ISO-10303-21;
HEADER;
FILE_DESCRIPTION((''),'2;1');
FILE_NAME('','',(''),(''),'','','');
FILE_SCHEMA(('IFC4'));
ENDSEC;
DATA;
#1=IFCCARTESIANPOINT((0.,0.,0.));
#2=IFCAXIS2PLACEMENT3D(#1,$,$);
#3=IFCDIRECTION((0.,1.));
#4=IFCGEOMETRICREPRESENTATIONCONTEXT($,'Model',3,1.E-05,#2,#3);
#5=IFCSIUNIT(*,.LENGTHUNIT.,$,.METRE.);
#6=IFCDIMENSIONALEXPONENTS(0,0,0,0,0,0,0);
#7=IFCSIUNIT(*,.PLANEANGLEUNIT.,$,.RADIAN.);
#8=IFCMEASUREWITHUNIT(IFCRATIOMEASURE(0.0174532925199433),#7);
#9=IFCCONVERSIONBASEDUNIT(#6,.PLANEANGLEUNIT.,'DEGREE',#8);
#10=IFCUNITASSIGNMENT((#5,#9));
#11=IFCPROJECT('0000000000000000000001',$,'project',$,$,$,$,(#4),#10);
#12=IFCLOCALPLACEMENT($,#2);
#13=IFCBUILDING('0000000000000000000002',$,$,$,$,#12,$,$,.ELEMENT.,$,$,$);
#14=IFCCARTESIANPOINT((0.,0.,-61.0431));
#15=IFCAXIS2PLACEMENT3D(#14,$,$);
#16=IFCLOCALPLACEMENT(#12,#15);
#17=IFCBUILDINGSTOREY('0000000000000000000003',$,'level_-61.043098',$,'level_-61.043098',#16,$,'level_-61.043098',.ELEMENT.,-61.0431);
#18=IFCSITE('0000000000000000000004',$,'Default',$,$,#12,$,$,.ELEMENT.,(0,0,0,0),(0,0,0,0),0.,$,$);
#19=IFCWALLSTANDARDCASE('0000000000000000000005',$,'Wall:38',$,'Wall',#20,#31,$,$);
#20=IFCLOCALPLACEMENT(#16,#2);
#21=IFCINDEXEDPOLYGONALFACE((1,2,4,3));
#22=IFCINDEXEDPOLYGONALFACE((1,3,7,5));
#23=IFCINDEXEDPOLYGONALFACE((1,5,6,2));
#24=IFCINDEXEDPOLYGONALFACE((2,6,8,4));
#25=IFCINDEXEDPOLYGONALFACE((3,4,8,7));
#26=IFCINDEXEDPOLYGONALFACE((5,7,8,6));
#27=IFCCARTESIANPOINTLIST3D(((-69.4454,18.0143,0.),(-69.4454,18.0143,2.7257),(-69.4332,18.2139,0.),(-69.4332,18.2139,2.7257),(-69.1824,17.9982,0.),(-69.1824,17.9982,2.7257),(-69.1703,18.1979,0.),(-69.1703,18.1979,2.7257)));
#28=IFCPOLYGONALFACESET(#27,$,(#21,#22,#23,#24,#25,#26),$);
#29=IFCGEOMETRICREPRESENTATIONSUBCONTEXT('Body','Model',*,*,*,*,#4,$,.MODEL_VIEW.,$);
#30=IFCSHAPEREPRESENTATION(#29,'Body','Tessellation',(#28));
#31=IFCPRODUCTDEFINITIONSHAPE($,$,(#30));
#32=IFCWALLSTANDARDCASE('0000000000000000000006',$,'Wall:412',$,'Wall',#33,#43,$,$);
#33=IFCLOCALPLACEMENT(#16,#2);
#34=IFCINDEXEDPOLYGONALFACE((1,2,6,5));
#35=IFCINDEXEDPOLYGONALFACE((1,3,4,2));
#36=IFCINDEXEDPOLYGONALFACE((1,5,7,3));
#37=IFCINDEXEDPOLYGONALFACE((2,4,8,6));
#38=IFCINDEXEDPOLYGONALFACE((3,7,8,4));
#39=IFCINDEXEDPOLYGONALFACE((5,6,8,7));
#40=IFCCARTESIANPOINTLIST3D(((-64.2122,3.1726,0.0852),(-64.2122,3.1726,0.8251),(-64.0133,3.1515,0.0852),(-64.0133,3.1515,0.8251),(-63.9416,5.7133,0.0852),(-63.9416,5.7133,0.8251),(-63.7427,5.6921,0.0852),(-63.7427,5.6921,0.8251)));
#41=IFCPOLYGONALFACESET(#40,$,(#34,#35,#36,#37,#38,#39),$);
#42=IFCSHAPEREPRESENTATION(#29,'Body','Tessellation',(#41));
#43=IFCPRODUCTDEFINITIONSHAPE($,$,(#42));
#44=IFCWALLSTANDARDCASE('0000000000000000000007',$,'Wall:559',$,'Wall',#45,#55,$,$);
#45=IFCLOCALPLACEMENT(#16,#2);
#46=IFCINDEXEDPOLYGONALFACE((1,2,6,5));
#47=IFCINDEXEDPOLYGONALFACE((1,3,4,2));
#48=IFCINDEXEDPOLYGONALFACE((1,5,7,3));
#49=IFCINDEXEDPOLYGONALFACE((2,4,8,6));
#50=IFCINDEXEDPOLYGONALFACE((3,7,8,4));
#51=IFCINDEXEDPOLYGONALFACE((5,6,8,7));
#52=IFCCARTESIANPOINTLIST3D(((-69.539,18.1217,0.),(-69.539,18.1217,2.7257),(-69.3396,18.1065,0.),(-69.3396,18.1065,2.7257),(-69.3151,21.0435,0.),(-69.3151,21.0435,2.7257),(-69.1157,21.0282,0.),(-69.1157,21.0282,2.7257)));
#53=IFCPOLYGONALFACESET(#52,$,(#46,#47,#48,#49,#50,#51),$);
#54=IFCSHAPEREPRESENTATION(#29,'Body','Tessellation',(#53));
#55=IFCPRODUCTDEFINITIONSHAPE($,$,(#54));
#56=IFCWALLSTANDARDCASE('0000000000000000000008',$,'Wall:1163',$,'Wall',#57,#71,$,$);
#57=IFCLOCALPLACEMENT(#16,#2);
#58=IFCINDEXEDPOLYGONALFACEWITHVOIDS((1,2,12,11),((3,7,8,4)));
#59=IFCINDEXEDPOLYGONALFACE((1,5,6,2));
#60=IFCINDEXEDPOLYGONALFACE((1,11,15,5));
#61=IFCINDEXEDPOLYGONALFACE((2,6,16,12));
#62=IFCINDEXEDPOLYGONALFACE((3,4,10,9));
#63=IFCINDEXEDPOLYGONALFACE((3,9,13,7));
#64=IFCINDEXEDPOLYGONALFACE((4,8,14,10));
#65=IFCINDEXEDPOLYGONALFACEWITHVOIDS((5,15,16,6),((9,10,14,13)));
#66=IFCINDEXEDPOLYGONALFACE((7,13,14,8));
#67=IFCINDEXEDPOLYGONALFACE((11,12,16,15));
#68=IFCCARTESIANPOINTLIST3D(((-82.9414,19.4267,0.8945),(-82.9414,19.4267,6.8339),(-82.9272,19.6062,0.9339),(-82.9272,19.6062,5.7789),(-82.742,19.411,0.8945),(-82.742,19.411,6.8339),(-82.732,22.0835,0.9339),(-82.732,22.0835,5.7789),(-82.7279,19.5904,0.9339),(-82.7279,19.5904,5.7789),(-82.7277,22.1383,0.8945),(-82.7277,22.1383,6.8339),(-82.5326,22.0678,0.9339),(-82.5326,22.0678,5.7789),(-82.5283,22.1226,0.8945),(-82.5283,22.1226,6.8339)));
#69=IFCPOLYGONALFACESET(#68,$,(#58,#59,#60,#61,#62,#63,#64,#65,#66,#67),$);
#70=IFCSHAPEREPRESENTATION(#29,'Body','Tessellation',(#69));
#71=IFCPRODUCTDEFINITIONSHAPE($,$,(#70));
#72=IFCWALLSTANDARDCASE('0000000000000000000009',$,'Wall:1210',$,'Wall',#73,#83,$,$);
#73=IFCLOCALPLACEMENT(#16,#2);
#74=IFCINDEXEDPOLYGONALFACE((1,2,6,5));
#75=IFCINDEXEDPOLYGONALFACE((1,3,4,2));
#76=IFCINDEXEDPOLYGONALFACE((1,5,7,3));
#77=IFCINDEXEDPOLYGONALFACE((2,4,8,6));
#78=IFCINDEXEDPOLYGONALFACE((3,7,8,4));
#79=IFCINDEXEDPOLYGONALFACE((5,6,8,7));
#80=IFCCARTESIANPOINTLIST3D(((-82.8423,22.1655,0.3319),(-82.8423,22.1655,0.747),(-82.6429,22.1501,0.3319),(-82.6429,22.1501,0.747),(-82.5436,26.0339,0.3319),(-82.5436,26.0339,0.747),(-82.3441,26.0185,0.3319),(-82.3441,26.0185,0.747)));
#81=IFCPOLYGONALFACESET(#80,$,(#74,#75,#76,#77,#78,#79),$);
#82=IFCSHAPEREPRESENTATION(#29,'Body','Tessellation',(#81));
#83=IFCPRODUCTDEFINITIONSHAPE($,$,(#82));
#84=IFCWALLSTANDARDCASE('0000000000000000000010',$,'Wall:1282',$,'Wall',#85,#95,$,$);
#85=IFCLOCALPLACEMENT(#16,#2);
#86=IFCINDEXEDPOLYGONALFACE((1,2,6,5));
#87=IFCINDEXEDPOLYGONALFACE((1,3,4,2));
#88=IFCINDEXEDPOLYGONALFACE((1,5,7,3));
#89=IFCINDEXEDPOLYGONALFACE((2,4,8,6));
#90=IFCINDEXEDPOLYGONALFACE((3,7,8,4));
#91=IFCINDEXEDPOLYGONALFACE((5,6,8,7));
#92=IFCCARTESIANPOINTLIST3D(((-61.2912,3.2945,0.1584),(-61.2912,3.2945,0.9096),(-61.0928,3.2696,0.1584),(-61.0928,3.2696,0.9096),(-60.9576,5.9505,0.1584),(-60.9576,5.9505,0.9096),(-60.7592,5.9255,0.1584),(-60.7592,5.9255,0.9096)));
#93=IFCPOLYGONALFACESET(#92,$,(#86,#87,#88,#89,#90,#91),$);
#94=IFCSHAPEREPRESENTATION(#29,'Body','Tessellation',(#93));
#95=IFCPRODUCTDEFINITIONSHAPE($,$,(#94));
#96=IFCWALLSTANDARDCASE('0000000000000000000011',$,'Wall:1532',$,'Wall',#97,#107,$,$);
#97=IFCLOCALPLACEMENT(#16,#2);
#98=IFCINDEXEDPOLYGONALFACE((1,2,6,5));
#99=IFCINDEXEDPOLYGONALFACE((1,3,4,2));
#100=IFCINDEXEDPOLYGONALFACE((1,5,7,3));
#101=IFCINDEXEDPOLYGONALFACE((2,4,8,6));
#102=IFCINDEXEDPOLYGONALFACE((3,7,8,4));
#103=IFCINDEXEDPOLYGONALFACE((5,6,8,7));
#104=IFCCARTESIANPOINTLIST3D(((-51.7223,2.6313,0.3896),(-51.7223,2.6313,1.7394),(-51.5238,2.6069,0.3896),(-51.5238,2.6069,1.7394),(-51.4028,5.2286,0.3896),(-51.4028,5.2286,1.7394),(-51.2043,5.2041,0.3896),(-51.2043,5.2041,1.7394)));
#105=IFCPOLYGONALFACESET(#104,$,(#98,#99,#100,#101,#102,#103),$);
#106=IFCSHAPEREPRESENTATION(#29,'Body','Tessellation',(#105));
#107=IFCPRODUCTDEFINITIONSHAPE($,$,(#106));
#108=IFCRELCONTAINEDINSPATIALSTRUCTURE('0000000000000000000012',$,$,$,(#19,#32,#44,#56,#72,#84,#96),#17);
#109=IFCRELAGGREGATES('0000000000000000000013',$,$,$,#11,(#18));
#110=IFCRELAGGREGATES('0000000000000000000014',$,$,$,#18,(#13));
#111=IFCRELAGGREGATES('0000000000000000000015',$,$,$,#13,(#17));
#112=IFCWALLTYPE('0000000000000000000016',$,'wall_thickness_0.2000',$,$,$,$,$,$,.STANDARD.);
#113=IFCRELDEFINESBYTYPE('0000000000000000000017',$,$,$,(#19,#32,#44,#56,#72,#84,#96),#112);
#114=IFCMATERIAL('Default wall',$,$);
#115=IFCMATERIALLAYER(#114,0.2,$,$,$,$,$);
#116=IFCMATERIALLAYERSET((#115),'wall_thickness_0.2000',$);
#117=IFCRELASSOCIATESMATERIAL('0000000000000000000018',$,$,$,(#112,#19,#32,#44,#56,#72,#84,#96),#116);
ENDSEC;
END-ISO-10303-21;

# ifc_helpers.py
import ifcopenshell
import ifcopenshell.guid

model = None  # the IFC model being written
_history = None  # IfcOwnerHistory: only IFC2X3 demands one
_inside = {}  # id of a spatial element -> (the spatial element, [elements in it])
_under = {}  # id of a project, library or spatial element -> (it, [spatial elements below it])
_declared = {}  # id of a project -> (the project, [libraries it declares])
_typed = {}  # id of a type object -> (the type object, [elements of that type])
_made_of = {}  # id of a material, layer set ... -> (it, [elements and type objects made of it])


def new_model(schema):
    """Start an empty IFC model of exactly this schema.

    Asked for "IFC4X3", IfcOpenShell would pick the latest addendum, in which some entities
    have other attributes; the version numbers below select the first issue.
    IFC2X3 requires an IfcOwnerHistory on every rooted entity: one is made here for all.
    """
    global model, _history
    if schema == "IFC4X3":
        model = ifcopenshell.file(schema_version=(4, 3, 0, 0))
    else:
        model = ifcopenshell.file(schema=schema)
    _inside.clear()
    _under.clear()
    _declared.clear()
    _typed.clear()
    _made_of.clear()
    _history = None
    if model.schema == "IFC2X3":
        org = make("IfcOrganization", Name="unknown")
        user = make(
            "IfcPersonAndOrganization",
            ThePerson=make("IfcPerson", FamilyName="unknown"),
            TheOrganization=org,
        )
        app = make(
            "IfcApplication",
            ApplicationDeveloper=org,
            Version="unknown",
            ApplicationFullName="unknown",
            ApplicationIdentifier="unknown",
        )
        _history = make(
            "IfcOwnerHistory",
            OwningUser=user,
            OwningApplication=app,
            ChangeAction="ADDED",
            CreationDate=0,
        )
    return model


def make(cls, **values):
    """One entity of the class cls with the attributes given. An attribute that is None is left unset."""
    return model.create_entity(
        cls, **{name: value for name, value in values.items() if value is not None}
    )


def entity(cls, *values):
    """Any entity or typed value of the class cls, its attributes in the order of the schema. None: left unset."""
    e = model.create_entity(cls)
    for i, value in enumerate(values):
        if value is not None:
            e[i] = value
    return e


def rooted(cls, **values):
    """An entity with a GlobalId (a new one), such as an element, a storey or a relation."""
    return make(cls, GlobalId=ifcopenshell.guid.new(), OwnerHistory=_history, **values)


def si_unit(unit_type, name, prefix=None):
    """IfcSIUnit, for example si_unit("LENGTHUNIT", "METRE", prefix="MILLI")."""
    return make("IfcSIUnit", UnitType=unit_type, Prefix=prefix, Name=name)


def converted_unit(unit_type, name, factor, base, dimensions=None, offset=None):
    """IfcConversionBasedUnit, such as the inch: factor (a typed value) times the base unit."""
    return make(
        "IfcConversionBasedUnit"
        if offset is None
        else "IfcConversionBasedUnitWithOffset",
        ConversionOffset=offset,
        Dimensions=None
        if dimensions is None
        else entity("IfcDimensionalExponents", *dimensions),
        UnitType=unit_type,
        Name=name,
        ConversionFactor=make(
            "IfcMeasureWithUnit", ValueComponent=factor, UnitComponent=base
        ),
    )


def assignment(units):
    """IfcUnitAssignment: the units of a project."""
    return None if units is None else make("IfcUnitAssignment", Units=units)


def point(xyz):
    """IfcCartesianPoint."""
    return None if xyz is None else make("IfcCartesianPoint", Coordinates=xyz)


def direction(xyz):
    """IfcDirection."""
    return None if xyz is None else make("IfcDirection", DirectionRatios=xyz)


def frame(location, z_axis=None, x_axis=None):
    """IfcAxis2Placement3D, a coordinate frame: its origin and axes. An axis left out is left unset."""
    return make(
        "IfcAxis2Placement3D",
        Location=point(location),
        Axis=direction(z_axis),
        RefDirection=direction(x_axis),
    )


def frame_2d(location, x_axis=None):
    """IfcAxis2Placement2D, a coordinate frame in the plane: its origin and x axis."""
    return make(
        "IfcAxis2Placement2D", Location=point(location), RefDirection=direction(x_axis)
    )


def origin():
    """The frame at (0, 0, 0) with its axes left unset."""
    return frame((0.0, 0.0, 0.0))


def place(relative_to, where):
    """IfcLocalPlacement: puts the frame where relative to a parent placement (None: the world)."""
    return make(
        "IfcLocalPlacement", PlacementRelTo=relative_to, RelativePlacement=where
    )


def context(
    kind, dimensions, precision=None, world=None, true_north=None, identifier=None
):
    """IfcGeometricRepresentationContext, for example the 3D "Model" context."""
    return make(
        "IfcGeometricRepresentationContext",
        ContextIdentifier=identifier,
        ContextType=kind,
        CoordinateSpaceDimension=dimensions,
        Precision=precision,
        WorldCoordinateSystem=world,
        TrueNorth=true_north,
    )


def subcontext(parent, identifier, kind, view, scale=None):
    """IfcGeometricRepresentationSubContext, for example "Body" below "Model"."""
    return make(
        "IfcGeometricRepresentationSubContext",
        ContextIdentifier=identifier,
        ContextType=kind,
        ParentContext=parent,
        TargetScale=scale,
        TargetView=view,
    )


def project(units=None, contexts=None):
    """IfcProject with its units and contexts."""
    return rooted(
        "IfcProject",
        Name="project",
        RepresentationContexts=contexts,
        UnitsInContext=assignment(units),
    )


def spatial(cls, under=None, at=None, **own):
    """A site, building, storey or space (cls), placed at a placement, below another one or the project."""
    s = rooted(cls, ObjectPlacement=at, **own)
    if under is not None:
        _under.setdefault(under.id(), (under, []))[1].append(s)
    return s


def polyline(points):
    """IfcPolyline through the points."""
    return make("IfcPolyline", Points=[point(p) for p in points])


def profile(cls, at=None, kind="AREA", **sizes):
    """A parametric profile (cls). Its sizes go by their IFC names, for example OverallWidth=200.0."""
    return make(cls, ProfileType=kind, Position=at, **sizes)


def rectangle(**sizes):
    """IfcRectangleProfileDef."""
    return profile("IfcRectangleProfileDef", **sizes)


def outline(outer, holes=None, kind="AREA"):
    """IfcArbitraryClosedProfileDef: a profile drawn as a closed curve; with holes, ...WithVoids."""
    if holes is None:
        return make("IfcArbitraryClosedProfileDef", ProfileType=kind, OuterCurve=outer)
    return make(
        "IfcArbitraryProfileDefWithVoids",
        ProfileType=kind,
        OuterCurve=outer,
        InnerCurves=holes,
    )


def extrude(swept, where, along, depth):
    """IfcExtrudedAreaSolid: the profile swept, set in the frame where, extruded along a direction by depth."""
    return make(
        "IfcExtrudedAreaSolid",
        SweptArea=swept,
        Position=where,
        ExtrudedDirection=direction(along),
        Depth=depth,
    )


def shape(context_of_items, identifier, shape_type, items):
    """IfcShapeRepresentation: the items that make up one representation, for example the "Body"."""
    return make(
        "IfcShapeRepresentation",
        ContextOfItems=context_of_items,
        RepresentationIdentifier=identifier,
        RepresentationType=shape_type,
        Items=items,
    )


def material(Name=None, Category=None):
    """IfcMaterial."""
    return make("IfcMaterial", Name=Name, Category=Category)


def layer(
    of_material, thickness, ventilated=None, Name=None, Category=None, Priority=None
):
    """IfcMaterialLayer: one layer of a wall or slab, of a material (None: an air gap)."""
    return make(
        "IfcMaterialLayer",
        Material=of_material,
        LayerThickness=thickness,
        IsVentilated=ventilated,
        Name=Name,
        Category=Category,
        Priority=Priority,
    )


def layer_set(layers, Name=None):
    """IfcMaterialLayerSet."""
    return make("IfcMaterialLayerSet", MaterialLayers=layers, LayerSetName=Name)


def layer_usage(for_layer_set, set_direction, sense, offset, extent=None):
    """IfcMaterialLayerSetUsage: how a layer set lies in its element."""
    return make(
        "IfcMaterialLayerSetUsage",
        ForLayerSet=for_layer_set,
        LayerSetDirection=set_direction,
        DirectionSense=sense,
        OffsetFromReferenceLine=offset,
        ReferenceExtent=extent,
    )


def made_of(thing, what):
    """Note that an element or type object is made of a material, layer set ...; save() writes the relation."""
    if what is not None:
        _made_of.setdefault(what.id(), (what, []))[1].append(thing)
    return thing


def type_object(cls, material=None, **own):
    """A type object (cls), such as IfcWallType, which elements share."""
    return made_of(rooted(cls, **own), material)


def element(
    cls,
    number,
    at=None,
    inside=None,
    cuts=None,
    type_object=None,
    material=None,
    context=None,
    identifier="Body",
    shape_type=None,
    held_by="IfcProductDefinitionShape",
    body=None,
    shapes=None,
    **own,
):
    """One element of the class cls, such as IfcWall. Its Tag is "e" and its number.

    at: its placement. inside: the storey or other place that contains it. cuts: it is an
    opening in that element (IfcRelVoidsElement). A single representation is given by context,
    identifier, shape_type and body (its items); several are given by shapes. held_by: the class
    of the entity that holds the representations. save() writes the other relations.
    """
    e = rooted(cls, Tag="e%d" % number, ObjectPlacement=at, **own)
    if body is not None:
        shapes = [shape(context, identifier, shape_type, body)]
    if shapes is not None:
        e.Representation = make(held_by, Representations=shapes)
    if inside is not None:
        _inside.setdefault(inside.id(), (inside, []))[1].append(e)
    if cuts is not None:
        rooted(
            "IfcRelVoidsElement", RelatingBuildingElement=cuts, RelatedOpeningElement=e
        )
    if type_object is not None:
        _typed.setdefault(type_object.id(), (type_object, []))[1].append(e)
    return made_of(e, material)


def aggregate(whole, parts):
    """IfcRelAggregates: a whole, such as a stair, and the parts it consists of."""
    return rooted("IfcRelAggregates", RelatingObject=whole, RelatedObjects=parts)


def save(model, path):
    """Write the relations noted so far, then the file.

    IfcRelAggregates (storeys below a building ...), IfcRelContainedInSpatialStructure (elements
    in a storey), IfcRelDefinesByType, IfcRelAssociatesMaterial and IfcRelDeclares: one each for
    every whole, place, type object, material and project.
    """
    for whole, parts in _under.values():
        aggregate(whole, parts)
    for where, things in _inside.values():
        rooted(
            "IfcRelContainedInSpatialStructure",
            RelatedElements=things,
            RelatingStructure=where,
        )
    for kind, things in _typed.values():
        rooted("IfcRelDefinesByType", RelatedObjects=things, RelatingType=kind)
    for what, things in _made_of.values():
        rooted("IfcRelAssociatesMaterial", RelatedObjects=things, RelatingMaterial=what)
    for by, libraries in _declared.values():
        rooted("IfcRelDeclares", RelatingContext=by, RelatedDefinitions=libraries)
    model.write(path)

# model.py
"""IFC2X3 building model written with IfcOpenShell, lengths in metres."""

from ifc_helpers import new_model, entity, si_unit, converted_unit, direction, frame, frame_2d, origin, place, context, subcontext, project, spatial, polyline, rectangle, outline, extrude, material, layer, layer_set, layer_usage, type_object, element, save


model = new_model("IFC2X3")

# Units and contexts
model_context = context("Model", 3, precision=1e-05, world=origin(), true_north=direction((0.0, 1.0)))
body_context = subcontext(model_context, "Body", "Model", "MODEL_VIEW")
ifc_project = project(units=[si_unit("LENGTHUNIT", "METRE"), converted_unit("PLANEANGLEUNIT", "DEGREE", entity("IfcRatioMeasure", 0.0174532925199433), si_unit("PLANEANGLEUNIT", "RADIAN"), dimensions=[0, 0, 0, 0, 0, 0, 0])], contexts=[model_context])

# Site, building, storey
placement_1 = place(None, origin())
site = spatial("IfcSite", under=ifc_project, at=placement_1, Name="Default", CompositionType="ELEMENT", RefLatitude=(0, 0, 0, 0), RefLongitude=(0, 0, 0, 0), RefElevation=0.0)
building = spatial("IfcBuilding", under=site, at=placement_1, CompositionType="ELEMENT")
storey_placement = place(placement_1, frame((0.0, 0.0, -61.0431)))
storey = spatial("IfcBuildingStorey", under=building, at=storey_placement, Name="level_-61.043098", ObjectType="level_-61.043098", LongName="level_-61.043098", CompositionType="ELEMENT", Elevation=-61.0431)

# Walls
ifc_material_1 = material(Name="Default wall")
ifc_layer = layer(ifc_material_1, 0.2)
ifc_layer_set = layer_set([ifc_layer], Name="wall_thickness_0.2000")
ifc_layer_usage = layer_usage(ifc_layer_set, "AXIS2", "POSITIVE", -0.1)
wall_type = type_object("IfcWallType", Name="wall_thickness_0.2000", PredefinedType="STANDARD", material=ifc_layer_set)
wall_1_placement = place(storey_placement, frame((-69.1764, 18.0981, 0.0), z_axis=(0.0, 0.0, 1.0), x_axis=(-0.998144, 0.060905, 0.0)))
element("IfcWallStandardCase", 1, at=wall_1_placement, inside=storey, type_object=wall_type, material=ifc_layer_usage, Name="Wall:38", ObjectType="Wall", context=body_context, shape_type="SweptSolid", body=[
    extrude(outline(polyline([(0.2634, -0.1), (0.2634, 0.1), (0.0, 0.1), (0.0, -0.1), (0.2634, -0.1)])), origin(), (0.0, 0.0, 1.0), 2.7257),
])
placement_2 = place(placement_1, frame((0.0, 0.0, -60.9579)))
wall_2_placement = place(placement_2, frame((-64.1127, 3.162, 0.0), z_axis=(0.0, 0.0, 1.0), x_axis=(0.105898, 0.994377, 0.0)))
element("IfcWallStandardCase", 2, at=wall_2_placement, inside=storey, type_object=wall_type, material=ifc_layer_usage, Name="Wall:412", ObjectType="Wall", context=body_context, shape_type="SweptSolid", body=[
    extrude(outline(polyline([(2.555, -0.1), (2.555, 0.1), (0.0, 0.1), (0.0, -0.1), (2.555, -0.1)])), origin(), (0.0, 0.0, 1.0), 0.7399),
])
wall_3_placement = place(storey_placement, frame((-69.2154, 21.0358, 0.0), z_axis=(0.0, 0.0, 1.0), x_axis=(-0.076408, -0.997077, 0.0)))
element("IfcWallStandardCase", 3, at=wall_3_placement, inside=storey, type_object=wall_type, material=ifc_layer_usage, Name="Wall:559", ObjectType="Wall", context=body_context, shape_type="SweptSolid", body=[
    extrude(outline(polyline([(2.9303, -0.1), (2.9303, 0.1), (0.0, 0.1), (0.0, -0.1), (2.9303, -0.1)])), origin(), (0.0, 0.0, 1.0), 2.7257),
])

# Wall, opening
placement_3 = place(placement_1, frame((0.0, 0.0, -60.1486)))
wall_4_placement = place(placement_3, frame((-82.628, 22.1305, 0.0), z_axis=(0.0, 0.0, 1.0), x_axis=(-0.078563, -0.996909, 0.0)))
wall_4 = element("IfcWallStandardCase", 4, at=wall_4_placement, inside=storey, type_object=wall_type, material=ifc_layer_usage, Name="Wall:1163", ObjectType="Wall", context=body_context, shape_type="SweptSolid", body=[
    extrude(outline(polyline([(2.72, -0.1), (2.72, 0.1), (0.0, 0.1), (0.0, -0.1), (2.72, -0.1)])), origin(), (0.0, 0.0, 1.0), 5.9394),
])
opening_1_placement = place(wall_4_placement, frame((0.055, -0.1, 0.0394)))
element("IfcOpeningElement", 5, at=opening_1_placement, cuts=wall_4, ObjectType="Opening", context=body_context, shape_type="SweptSolid", body=[
    extrude(rectangle(XDim=2.485, YDim=4.845, at=frame_2d((2.4225, 1.2425), x_axis=(0.0, 1.0))), frame((0.0, 0.0, 0.0), z_axis=(0.0, 1.0, 0.0), x_axis=(0.0, 0.0, 1.0)), (0.0, 0.0, 1.0), 0.2),
])

# Walls
placement_4 = place(placement_1, frame((0.0, 0.0, -60.7112)))
wall_5_placement = place(placement_4, frame((-82.7426, 22.1578, 0.0), z_axis=(0.0, 0.0, 1.0), x_axis=(0.076998, 0.997031, 0.0)))
element("IfcWallStandardCase", 6, at=wall_5_placement, inside=storey, type_object=wall_type, material=ifc_layer_usage, Name="Wall:1210", ObjectType="Wall", context=body_context, shape_type="SweptSolid", body=[
    extrude(outline(polyline([(3.88, -0.1), (3.88, 0.1), (0.0, 0.1), (0.0, -0.1), (3.88, -0.1)])), origin(), (0.0, 0.0, 1.0), 0.4151),
])
placement_5 = place(placement_1, frame((0.0, 0.0, -60.8847)))
wall_6_placement = place(placement_5, frame((-61.192, 3.282, 0.0), z_axis=(0.0, 0.0, 1.0), x_axis=(0.124629, 0.992203, 0.0)))
element("IfcWallStandardCase", 7, at=wall_6_placement, inside=storey, type_object=wall_type, material=ifc_layer_usage, Name="Wall:1282", ObjectType="Wall", context=body_context, shape_type="SweptSolid", body=[
    extrude(outline(polyline([(2.6768, -0.1), (2.6768, 0.1), (0.0, 0.1), (0.0, -0.1), (2.6768, -0.1)])), origin(), (0.0, 0.0, 1.0), 0.7512),
])
placement_6 = place(placement_1, frame((0.0, 0.0, -60.6535)))
wall_7_placement = place(placement_6, frame((-51.6231, 2.6191, 0.0), z_axis=(0.0, 0.0, 1.0), x_axis=(0.122114, 0.992516, 0.0)))
element("IfcWallStandardCase", 8, at=wall_7_placement, inside=storey, type_object=wall_type, material=ifc_layer_usage, Name="Wall:1532", ObjectType="Wall", context=body_context, shape_type="SweptSolid", body=[
    extrude(outline(polyline([(2.6168, -0.1), (2.6168, 0.1), (0.0, 0.1), (0.0, -0.1), (2.6168, -0.1)])), origin(), (0.0, 0.0, 1.0), 1.3499),
])

save(model, "model.ifc")
